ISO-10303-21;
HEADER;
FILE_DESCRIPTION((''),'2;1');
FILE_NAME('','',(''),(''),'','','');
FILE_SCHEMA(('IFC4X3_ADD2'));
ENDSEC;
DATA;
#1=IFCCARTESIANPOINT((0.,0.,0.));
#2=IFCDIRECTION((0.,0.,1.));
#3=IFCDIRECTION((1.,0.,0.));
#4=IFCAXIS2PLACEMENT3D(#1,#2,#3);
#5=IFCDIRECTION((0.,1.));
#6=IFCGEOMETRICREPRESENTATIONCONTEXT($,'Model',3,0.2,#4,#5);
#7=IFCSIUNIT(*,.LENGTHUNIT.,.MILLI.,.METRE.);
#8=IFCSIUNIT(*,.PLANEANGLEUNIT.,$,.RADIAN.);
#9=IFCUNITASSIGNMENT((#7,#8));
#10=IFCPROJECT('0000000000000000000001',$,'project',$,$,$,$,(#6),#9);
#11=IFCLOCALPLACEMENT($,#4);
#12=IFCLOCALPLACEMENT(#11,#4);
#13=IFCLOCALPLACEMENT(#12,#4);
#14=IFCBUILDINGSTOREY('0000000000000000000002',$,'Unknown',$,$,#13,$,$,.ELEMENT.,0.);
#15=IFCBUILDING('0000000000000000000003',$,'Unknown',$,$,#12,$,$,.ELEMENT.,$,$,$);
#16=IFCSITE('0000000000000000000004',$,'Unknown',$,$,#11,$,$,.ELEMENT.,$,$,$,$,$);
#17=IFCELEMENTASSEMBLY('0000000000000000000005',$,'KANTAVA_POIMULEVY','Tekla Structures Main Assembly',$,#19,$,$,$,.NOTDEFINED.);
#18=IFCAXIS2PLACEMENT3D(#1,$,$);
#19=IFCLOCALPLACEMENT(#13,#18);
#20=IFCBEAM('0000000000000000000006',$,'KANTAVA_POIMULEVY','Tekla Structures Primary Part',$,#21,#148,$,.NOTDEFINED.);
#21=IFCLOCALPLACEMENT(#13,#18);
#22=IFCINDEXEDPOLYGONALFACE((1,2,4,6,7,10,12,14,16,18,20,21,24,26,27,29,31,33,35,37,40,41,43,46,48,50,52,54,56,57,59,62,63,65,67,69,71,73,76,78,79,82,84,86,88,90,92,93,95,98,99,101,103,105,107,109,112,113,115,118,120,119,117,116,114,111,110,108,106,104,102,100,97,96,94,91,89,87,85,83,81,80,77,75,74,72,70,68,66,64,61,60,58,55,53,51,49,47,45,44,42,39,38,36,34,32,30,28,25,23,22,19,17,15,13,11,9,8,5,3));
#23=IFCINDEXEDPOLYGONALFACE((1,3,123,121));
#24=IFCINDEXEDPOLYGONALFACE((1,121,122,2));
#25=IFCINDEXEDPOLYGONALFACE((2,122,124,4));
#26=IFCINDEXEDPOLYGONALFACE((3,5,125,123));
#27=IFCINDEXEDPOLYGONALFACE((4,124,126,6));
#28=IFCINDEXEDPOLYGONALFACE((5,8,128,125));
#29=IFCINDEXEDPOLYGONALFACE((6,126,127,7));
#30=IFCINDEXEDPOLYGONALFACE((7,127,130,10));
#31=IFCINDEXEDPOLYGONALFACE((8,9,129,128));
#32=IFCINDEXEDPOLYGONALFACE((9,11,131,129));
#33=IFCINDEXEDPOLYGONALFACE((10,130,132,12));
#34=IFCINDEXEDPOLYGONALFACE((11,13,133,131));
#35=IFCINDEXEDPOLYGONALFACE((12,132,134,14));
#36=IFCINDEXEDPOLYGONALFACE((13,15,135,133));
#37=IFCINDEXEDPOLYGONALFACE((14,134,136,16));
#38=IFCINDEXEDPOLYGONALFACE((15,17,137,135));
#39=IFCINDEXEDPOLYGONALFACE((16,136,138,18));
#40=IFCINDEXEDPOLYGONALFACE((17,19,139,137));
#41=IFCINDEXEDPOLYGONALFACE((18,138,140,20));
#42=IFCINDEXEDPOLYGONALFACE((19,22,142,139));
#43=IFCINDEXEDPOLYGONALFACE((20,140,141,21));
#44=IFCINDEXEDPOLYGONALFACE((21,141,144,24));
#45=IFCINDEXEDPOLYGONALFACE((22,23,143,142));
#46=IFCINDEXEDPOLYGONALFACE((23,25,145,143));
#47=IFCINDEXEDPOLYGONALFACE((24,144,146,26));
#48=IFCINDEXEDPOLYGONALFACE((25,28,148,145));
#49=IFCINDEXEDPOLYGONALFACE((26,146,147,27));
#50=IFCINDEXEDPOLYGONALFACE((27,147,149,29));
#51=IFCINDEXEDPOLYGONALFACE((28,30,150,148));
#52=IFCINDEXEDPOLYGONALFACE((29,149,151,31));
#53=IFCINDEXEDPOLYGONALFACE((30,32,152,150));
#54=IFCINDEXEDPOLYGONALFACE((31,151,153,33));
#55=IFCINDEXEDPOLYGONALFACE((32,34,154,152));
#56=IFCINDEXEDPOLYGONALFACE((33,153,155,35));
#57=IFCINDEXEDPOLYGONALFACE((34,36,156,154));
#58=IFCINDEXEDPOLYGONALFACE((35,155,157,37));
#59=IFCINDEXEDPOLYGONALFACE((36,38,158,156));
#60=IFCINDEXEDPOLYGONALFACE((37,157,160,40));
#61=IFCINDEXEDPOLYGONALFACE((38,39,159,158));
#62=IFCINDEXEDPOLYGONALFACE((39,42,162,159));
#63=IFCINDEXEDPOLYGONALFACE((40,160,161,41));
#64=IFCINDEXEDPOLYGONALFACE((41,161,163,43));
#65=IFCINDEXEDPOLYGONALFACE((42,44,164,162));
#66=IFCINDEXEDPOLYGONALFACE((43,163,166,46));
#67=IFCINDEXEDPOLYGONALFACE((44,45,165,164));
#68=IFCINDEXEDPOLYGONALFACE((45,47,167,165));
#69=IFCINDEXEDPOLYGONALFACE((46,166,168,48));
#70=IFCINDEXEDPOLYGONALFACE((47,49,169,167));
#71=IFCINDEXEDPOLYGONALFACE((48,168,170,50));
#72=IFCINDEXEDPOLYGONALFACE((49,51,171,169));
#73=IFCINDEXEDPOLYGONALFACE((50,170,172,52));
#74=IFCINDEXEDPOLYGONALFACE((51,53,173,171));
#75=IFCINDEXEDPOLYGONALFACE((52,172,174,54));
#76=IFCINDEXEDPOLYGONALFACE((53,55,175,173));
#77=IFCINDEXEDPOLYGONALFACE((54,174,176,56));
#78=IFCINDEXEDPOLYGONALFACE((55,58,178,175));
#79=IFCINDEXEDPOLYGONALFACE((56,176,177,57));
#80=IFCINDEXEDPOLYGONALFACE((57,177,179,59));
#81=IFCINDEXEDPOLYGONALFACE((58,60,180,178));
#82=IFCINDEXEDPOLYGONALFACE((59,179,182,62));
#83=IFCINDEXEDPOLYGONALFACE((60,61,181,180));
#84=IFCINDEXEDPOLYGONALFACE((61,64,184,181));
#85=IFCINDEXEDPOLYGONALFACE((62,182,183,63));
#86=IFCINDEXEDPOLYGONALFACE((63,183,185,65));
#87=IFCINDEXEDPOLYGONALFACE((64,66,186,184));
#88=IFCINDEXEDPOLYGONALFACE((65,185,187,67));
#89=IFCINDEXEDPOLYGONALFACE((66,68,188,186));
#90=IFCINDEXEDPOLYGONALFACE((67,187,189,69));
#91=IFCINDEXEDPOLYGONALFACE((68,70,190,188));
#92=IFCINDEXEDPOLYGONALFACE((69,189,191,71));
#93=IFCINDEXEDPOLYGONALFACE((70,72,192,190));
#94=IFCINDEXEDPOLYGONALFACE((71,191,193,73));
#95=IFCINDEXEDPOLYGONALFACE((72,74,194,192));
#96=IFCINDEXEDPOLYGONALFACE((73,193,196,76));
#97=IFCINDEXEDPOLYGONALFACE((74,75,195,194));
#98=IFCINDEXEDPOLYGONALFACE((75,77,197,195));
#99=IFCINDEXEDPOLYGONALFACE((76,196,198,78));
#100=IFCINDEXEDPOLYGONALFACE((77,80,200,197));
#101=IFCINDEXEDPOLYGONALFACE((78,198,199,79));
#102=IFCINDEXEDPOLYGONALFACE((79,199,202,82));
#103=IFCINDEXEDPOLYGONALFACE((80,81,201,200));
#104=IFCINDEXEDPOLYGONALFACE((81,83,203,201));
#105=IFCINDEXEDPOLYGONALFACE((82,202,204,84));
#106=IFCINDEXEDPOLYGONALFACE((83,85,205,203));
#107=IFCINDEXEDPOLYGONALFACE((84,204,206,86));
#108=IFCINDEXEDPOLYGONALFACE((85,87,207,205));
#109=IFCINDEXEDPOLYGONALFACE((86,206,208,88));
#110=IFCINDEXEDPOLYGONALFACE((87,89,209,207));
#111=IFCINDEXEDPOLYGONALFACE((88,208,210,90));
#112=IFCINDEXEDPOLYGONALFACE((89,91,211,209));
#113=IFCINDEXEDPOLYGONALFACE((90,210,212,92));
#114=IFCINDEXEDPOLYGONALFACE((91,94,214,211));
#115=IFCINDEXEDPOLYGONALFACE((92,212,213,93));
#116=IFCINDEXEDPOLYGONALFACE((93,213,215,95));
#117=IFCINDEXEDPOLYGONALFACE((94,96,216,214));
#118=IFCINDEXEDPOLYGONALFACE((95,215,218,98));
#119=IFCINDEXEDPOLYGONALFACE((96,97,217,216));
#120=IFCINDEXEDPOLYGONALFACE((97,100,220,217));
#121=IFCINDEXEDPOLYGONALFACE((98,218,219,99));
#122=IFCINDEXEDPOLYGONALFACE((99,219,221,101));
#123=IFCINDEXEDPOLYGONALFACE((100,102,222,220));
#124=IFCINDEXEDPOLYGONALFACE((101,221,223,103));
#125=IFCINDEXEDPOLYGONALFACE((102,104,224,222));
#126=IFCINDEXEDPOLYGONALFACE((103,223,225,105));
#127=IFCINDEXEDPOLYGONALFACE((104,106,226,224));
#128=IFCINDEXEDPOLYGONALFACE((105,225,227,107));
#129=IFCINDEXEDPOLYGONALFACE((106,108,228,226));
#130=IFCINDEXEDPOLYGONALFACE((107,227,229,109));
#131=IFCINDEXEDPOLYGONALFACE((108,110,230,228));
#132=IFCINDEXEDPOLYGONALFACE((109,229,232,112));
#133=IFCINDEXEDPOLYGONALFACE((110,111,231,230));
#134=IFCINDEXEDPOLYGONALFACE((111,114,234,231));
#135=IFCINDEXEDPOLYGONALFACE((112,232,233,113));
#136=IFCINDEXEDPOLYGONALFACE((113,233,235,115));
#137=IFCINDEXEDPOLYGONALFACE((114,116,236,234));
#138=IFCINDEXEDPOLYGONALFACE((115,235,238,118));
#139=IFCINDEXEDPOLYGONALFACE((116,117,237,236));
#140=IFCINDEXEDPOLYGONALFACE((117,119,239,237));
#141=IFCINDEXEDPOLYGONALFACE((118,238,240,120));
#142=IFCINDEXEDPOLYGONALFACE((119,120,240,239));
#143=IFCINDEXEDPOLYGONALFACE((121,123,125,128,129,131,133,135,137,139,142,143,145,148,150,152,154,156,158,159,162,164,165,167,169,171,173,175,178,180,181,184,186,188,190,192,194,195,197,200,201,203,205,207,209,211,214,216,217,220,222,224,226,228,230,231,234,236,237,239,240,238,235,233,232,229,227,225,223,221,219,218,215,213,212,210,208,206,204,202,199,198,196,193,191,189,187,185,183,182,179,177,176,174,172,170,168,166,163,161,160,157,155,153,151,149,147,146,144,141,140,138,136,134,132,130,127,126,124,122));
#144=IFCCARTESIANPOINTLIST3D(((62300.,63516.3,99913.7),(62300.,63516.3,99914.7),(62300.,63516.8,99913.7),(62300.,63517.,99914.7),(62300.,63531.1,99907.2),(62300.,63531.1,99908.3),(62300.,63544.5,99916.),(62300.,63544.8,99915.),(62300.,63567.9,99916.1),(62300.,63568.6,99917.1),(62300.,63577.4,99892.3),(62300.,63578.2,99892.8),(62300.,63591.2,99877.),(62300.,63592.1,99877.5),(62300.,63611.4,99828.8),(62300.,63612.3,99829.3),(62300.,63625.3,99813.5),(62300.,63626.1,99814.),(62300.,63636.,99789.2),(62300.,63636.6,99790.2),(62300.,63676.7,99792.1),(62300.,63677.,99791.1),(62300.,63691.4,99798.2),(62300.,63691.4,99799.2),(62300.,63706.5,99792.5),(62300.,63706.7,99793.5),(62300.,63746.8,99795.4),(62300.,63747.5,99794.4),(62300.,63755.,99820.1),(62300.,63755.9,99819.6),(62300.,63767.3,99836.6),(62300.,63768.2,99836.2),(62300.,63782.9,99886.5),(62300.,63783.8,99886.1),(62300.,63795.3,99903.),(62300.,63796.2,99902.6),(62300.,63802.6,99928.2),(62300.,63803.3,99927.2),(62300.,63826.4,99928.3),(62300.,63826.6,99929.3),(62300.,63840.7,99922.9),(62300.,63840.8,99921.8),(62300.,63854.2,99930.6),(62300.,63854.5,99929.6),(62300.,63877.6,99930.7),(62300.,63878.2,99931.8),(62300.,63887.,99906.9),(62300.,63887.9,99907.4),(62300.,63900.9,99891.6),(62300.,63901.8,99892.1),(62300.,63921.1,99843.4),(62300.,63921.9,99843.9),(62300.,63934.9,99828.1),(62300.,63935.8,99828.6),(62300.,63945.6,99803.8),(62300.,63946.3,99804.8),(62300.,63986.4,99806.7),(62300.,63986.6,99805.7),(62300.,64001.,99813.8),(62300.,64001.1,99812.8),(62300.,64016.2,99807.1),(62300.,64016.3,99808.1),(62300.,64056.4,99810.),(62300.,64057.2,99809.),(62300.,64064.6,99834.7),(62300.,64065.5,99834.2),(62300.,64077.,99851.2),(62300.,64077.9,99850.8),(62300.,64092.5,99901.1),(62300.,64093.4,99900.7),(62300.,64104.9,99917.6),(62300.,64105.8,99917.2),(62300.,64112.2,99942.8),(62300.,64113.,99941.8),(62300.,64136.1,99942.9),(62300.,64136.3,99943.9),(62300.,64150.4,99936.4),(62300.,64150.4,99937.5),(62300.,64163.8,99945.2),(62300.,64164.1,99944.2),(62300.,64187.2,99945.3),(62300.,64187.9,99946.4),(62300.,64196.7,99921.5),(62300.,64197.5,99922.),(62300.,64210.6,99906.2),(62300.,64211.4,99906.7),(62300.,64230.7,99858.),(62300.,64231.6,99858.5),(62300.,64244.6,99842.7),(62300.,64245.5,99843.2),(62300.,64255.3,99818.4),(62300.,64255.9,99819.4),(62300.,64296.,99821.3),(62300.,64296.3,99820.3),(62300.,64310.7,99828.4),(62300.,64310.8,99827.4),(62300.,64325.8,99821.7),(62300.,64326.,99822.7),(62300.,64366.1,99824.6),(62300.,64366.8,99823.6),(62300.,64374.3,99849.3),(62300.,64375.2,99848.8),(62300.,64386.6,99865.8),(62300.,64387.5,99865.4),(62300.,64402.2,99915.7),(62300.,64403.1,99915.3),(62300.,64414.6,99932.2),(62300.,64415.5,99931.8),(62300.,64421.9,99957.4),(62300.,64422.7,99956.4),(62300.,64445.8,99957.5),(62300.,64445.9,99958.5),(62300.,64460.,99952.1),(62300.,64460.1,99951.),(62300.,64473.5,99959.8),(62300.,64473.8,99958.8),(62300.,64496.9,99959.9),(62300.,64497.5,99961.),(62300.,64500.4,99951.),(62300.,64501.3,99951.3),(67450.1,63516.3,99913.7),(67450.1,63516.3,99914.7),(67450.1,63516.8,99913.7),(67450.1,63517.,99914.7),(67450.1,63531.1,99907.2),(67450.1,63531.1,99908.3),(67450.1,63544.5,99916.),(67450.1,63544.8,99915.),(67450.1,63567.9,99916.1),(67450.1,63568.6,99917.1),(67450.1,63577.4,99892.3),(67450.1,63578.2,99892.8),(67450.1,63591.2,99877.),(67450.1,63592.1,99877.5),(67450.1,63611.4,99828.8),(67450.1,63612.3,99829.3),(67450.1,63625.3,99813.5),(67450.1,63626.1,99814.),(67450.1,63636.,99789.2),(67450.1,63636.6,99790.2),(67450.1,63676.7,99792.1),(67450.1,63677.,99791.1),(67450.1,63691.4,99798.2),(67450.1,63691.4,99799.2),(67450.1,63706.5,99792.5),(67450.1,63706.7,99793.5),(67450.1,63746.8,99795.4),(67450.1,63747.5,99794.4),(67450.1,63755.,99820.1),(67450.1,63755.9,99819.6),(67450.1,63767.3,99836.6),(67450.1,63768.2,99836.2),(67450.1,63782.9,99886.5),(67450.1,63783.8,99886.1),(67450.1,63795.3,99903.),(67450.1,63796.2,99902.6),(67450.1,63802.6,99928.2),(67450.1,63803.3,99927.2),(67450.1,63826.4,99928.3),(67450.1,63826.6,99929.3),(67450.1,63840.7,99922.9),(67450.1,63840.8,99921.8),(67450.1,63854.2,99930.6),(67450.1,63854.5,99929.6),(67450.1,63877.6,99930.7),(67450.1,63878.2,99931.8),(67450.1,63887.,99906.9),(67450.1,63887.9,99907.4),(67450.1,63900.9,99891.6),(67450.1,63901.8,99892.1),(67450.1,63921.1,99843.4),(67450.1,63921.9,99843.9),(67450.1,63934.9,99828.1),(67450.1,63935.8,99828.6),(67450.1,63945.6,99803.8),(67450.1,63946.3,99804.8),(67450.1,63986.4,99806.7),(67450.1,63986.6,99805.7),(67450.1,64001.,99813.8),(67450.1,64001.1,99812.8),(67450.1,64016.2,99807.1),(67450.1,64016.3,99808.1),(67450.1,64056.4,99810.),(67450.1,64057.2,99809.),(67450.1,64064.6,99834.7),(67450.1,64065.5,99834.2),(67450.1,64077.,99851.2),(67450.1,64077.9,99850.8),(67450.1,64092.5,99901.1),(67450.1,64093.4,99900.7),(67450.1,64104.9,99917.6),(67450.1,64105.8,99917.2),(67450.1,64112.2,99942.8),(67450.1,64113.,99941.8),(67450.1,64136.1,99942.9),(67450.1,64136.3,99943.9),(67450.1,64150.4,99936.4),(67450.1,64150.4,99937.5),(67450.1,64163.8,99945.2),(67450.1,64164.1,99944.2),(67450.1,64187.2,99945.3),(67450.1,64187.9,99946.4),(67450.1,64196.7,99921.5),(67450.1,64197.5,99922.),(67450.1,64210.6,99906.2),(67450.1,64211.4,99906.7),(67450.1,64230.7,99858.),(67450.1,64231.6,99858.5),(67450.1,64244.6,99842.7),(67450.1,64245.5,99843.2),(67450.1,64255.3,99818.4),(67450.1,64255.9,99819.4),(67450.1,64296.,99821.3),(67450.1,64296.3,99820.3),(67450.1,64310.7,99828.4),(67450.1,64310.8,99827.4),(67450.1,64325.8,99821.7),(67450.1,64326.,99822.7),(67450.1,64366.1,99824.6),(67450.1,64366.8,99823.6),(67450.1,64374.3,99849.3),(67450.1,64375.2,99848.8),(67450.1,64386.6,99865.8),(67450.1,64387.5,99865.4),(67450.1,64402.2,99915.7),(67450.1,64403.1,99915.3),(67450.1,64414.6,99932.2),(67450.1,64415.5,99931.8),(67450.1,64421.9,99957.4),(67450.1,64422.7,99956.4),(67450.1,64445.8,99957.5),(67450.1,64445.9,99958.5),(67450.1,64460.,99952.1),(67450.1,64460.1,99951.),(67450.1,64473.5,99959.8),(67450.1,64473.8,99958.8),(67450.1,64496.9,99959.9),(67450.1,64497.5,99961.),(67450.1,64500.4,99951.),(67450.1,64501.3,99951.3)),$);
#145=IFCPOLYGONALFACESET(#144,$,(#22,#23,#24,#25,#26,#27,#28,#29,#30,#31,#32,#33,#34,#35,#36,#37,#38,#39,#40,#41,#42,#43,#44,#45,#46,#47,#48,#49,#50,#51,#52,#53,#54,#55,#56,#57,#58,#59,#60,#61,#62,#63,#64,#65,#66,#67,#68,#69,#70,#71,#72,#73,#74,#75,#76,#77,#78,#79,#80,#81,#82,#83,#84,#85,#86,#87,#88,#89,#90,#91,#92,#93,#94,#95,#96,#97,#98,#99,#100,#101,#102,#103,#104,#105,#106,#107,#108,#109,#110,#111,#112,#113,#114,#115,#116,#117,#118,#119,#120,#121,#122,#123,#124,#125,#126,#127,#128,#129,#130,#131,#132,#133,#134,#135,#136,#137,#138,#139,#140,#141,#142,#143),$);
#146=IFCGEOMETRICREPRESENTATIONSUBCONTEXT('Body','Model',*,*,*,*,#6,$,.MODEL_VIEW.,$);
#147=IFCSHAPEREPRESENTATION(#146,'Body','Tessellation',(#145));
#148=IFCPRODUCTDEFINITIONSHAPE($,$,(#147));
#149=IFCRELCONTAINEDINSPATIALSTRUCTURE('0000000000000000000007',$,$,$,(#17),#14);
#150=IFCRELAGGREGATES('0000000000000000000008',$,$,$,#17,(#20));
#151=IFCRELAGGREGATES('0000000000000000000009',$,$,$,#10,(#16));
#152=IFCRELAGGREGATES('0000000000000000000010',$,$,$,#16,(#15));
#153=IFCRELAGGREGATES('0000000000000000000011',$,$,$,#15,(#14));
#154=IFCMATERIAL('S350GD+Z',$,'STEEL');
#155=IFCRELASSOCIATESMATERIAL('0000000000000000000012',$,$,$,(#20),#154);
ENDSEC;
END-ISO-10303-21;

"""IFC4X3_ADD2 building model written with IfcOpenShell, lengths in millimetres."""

from ifc_helpers import new_model, si_unit, direction, frame, origin_with_axes, place, context, subcontext, project, spatial, line, indexed_curve, outline, extrude, material, element, aggregate, save


model = new_model("IFC4X3_ADD2")

# Units and contexts
model_context = context("Model", 3, precision=0.2, world=origin_with_axes(), true_north=direction((0.0, 1.0)))
body_context = subcontext(model_context, "Body", "Model", "MODEL_VIEW")
ifc_project = project(units=[si_unit("LENGTHUNIT", "METRE", prefix="MILLI"), si_unit("PLANEANGLEUNIT", "RADIAN")], contexts=[model_context])

# Site, building, storey
site_placement = place(None, origin_with_axes())
site = spatial("IfcSite", under=ifc_project, at=site_placement, Name="Unknown", CompositionType="ELEMENT")
building_placement = place(site_placement, origin_with_axes())
building = spatial("IfcBuilding", under=site, at=building_placement, Name="Unknown", CompositionType="ELEMENT")
storey_placement = place(building_placement, origin_with_axes())
storey = spatial("IfcBuildingStorey", under=building, at=storey_placement, Name="Unknown", CompositionType="ELEMENT", Elevation=0.0)

# Element assembly, beam
ifc_material_1 = material(Name="S350GD+Z", Category="STEEL")
assembly_1_placement = place(storey_placement, frame((62300.0, 63998.3, 99871.8), z_axis=(0.0, -0.99889, -0.047106), x_axis=(1.0, 0.0, 0.0)))
assembly_1 = element("IfcElementAssembly", 1, at=assembly_1_placement, inside=storey, Name="KANTAVA_POIMULEVY", Description="Tekla Structures Main Assembly", PredefinedType="NOTDEFINED")
beam_1_placement = place(assembly_1_placement, origin_with_axes())
beam_1 = element("IfcBeam", 2, at=beam_1_placement, material=ifc_material_1, Name="KANTAVA_POIMULEVY", Description="Tekla Structures Primary Part", PredefinedType="NOTDEFINED", context=body_context, shape_type="SolidModel", body=[
    extrude(outline(indexed_curve([(479.5, 65.5), (478.8, 65.5), (465.0, 58.5), (451.2, 65.5), (427.1, 65.5), (418.6, 40.7), (405.5, 24.8), (387.6, -24.3), (374.5, -40.2), (365.1, -64.5), (325.0, -64.5), (310.0, -58.1), (295.0, -64.5), (254.8, -64.5), (245.5, -40.2), (232.4, -24.3), (214.5, 24.8), (201.4, 40.7), (192.9, 65.5), (168.8, 65.5), (155.0, 58.5), (141.2, 65.5), (117.1, 65.5), (108.6, 40.7), (95.5, 24.8), (77.6, -24.3), (64.5, -40.2), (55.1, -64.5), (15.0, -64.5), (0.0, -58.1), (-15.0, -64.5), (-55.2, -64.5), (-64.5, -40.2), (-77.6, -24.3), (-95.5, 24.8), (-108.6, 40.7), (-117.2, 65.5), (-141.2, 65.5), (-155.0, 58.5), (-168.8, 65.5), (-192.9, 65.5), (-201.4, 40.7), (-214.5, 24.8), (-232.4, -24.3), (-245.5, -40.2), (-254.9, -64.5), (-295.0, -64.5), (-310.0, -58.1), (-325.0, -64.5), (-365.2, -64.5), (-374.5, -40.2), (-387.6, -24.3), (-405.5, 24.8), (-418.6, 40.7), (-427.1, 65.5), (-451.2, 65.5), (-465.0, 58.5), (-478.8, 65.5), (-502.9, 65.5), (-506.2, 55.7), (-505.2, 55.4), (-502.1, 64.5), (-479.0, 64.5), (-465.0, 57.3), (-451.0, 64.5), (-427.9, 64.5), (-419.5, 40.2), (-406.4, 24.3), (-388.5, -24.8), (-375.4, -40.7), (-365.9, -65.5), (-324.8, -65.5), (-310.0, -59.1), (-295.2, -65.5), (-254.2, -65.5), (-244.6, -40.7), (-231.5, -24.8), (-213.6, 24.3), (-200.5, 40.2), (-192.1, 64.5), (-169.0, 64.5), (-155.0, 57.3), (-141.0, 64.5), (-117.9, 64.5), (-109.5, 40.2), (-96.4, 24.3), (-78.5, -24.8), (-65.4, -40.7), (-55.9, -65.5), (-14.8, -65.5), (0.0, -59.1), (14.8, -65.5), (55.8, -65.5), (65.4, -40.7), (78.5, -24.8), (96.4, 24.3), (109.5, 40.2), (117.8, 64.5), (141.0, 64.5), (155.0, 57.3), (169.0, 64.5), (192.1, 64.5), (200.5, 40.2), (213.6, 24.3), (231.5, -24.8), (244.6, -40.7), (254.1, -65.5), (295.2, -65.5), (310.0, -59.1), (324.8, -65.5), (365.8, -65.5), (375.4, -40.7), (388.5, -24.8), (406.4, 24.3), (419.5, 40.2), (427.9, 64.5), (451.0, 64.5), (465.0, 57.3), (479.0, 64.5), (479.5, 64.5)], segments=[line(1, 2, 3, 4, 5, 6, 7, 8, 9, 10, 11, 12, 13, 14, 15, 16, 17, 18, 19, 20, 21, 22, 23, 24, 25, 26, 27, 28, 29, 30, 31, 32, 33, 34, 35, 36, 37, 38, 39, 40, 41, 42, 43, 44, 45, 46, 47, 48, 49, 50, 51, 52, 53, 54, 55, 56, 57, 58, 59, 60, 61, 62, 63, 64, 65, 66, 67, 68, 69, 70, 71, 72, 73, 74, 75, 76, 77, 78, 79, 80, 81, 82, 83, 84, 85, 86, 87, 88, 89, 90, 91, 92, 93, 94, 95, 96, 97, 98, 99, 100, 101, 102, 103, 104, 105, 106, 107, 108, 109, 110, 111, 112, 113, 114, 115, 116, 117, 118, 119, 120, 1)])), frame((0.0, 0.0, 0.0), z_axis=(-1.0, 0.0, 0.0), x_axis=(0.0, 0.0, 1.0)), (0.0, 0.0, -1.0), 5150.1),
])
aggregate(assembly_1, [beam_1])

save(model, "model.ifc")
